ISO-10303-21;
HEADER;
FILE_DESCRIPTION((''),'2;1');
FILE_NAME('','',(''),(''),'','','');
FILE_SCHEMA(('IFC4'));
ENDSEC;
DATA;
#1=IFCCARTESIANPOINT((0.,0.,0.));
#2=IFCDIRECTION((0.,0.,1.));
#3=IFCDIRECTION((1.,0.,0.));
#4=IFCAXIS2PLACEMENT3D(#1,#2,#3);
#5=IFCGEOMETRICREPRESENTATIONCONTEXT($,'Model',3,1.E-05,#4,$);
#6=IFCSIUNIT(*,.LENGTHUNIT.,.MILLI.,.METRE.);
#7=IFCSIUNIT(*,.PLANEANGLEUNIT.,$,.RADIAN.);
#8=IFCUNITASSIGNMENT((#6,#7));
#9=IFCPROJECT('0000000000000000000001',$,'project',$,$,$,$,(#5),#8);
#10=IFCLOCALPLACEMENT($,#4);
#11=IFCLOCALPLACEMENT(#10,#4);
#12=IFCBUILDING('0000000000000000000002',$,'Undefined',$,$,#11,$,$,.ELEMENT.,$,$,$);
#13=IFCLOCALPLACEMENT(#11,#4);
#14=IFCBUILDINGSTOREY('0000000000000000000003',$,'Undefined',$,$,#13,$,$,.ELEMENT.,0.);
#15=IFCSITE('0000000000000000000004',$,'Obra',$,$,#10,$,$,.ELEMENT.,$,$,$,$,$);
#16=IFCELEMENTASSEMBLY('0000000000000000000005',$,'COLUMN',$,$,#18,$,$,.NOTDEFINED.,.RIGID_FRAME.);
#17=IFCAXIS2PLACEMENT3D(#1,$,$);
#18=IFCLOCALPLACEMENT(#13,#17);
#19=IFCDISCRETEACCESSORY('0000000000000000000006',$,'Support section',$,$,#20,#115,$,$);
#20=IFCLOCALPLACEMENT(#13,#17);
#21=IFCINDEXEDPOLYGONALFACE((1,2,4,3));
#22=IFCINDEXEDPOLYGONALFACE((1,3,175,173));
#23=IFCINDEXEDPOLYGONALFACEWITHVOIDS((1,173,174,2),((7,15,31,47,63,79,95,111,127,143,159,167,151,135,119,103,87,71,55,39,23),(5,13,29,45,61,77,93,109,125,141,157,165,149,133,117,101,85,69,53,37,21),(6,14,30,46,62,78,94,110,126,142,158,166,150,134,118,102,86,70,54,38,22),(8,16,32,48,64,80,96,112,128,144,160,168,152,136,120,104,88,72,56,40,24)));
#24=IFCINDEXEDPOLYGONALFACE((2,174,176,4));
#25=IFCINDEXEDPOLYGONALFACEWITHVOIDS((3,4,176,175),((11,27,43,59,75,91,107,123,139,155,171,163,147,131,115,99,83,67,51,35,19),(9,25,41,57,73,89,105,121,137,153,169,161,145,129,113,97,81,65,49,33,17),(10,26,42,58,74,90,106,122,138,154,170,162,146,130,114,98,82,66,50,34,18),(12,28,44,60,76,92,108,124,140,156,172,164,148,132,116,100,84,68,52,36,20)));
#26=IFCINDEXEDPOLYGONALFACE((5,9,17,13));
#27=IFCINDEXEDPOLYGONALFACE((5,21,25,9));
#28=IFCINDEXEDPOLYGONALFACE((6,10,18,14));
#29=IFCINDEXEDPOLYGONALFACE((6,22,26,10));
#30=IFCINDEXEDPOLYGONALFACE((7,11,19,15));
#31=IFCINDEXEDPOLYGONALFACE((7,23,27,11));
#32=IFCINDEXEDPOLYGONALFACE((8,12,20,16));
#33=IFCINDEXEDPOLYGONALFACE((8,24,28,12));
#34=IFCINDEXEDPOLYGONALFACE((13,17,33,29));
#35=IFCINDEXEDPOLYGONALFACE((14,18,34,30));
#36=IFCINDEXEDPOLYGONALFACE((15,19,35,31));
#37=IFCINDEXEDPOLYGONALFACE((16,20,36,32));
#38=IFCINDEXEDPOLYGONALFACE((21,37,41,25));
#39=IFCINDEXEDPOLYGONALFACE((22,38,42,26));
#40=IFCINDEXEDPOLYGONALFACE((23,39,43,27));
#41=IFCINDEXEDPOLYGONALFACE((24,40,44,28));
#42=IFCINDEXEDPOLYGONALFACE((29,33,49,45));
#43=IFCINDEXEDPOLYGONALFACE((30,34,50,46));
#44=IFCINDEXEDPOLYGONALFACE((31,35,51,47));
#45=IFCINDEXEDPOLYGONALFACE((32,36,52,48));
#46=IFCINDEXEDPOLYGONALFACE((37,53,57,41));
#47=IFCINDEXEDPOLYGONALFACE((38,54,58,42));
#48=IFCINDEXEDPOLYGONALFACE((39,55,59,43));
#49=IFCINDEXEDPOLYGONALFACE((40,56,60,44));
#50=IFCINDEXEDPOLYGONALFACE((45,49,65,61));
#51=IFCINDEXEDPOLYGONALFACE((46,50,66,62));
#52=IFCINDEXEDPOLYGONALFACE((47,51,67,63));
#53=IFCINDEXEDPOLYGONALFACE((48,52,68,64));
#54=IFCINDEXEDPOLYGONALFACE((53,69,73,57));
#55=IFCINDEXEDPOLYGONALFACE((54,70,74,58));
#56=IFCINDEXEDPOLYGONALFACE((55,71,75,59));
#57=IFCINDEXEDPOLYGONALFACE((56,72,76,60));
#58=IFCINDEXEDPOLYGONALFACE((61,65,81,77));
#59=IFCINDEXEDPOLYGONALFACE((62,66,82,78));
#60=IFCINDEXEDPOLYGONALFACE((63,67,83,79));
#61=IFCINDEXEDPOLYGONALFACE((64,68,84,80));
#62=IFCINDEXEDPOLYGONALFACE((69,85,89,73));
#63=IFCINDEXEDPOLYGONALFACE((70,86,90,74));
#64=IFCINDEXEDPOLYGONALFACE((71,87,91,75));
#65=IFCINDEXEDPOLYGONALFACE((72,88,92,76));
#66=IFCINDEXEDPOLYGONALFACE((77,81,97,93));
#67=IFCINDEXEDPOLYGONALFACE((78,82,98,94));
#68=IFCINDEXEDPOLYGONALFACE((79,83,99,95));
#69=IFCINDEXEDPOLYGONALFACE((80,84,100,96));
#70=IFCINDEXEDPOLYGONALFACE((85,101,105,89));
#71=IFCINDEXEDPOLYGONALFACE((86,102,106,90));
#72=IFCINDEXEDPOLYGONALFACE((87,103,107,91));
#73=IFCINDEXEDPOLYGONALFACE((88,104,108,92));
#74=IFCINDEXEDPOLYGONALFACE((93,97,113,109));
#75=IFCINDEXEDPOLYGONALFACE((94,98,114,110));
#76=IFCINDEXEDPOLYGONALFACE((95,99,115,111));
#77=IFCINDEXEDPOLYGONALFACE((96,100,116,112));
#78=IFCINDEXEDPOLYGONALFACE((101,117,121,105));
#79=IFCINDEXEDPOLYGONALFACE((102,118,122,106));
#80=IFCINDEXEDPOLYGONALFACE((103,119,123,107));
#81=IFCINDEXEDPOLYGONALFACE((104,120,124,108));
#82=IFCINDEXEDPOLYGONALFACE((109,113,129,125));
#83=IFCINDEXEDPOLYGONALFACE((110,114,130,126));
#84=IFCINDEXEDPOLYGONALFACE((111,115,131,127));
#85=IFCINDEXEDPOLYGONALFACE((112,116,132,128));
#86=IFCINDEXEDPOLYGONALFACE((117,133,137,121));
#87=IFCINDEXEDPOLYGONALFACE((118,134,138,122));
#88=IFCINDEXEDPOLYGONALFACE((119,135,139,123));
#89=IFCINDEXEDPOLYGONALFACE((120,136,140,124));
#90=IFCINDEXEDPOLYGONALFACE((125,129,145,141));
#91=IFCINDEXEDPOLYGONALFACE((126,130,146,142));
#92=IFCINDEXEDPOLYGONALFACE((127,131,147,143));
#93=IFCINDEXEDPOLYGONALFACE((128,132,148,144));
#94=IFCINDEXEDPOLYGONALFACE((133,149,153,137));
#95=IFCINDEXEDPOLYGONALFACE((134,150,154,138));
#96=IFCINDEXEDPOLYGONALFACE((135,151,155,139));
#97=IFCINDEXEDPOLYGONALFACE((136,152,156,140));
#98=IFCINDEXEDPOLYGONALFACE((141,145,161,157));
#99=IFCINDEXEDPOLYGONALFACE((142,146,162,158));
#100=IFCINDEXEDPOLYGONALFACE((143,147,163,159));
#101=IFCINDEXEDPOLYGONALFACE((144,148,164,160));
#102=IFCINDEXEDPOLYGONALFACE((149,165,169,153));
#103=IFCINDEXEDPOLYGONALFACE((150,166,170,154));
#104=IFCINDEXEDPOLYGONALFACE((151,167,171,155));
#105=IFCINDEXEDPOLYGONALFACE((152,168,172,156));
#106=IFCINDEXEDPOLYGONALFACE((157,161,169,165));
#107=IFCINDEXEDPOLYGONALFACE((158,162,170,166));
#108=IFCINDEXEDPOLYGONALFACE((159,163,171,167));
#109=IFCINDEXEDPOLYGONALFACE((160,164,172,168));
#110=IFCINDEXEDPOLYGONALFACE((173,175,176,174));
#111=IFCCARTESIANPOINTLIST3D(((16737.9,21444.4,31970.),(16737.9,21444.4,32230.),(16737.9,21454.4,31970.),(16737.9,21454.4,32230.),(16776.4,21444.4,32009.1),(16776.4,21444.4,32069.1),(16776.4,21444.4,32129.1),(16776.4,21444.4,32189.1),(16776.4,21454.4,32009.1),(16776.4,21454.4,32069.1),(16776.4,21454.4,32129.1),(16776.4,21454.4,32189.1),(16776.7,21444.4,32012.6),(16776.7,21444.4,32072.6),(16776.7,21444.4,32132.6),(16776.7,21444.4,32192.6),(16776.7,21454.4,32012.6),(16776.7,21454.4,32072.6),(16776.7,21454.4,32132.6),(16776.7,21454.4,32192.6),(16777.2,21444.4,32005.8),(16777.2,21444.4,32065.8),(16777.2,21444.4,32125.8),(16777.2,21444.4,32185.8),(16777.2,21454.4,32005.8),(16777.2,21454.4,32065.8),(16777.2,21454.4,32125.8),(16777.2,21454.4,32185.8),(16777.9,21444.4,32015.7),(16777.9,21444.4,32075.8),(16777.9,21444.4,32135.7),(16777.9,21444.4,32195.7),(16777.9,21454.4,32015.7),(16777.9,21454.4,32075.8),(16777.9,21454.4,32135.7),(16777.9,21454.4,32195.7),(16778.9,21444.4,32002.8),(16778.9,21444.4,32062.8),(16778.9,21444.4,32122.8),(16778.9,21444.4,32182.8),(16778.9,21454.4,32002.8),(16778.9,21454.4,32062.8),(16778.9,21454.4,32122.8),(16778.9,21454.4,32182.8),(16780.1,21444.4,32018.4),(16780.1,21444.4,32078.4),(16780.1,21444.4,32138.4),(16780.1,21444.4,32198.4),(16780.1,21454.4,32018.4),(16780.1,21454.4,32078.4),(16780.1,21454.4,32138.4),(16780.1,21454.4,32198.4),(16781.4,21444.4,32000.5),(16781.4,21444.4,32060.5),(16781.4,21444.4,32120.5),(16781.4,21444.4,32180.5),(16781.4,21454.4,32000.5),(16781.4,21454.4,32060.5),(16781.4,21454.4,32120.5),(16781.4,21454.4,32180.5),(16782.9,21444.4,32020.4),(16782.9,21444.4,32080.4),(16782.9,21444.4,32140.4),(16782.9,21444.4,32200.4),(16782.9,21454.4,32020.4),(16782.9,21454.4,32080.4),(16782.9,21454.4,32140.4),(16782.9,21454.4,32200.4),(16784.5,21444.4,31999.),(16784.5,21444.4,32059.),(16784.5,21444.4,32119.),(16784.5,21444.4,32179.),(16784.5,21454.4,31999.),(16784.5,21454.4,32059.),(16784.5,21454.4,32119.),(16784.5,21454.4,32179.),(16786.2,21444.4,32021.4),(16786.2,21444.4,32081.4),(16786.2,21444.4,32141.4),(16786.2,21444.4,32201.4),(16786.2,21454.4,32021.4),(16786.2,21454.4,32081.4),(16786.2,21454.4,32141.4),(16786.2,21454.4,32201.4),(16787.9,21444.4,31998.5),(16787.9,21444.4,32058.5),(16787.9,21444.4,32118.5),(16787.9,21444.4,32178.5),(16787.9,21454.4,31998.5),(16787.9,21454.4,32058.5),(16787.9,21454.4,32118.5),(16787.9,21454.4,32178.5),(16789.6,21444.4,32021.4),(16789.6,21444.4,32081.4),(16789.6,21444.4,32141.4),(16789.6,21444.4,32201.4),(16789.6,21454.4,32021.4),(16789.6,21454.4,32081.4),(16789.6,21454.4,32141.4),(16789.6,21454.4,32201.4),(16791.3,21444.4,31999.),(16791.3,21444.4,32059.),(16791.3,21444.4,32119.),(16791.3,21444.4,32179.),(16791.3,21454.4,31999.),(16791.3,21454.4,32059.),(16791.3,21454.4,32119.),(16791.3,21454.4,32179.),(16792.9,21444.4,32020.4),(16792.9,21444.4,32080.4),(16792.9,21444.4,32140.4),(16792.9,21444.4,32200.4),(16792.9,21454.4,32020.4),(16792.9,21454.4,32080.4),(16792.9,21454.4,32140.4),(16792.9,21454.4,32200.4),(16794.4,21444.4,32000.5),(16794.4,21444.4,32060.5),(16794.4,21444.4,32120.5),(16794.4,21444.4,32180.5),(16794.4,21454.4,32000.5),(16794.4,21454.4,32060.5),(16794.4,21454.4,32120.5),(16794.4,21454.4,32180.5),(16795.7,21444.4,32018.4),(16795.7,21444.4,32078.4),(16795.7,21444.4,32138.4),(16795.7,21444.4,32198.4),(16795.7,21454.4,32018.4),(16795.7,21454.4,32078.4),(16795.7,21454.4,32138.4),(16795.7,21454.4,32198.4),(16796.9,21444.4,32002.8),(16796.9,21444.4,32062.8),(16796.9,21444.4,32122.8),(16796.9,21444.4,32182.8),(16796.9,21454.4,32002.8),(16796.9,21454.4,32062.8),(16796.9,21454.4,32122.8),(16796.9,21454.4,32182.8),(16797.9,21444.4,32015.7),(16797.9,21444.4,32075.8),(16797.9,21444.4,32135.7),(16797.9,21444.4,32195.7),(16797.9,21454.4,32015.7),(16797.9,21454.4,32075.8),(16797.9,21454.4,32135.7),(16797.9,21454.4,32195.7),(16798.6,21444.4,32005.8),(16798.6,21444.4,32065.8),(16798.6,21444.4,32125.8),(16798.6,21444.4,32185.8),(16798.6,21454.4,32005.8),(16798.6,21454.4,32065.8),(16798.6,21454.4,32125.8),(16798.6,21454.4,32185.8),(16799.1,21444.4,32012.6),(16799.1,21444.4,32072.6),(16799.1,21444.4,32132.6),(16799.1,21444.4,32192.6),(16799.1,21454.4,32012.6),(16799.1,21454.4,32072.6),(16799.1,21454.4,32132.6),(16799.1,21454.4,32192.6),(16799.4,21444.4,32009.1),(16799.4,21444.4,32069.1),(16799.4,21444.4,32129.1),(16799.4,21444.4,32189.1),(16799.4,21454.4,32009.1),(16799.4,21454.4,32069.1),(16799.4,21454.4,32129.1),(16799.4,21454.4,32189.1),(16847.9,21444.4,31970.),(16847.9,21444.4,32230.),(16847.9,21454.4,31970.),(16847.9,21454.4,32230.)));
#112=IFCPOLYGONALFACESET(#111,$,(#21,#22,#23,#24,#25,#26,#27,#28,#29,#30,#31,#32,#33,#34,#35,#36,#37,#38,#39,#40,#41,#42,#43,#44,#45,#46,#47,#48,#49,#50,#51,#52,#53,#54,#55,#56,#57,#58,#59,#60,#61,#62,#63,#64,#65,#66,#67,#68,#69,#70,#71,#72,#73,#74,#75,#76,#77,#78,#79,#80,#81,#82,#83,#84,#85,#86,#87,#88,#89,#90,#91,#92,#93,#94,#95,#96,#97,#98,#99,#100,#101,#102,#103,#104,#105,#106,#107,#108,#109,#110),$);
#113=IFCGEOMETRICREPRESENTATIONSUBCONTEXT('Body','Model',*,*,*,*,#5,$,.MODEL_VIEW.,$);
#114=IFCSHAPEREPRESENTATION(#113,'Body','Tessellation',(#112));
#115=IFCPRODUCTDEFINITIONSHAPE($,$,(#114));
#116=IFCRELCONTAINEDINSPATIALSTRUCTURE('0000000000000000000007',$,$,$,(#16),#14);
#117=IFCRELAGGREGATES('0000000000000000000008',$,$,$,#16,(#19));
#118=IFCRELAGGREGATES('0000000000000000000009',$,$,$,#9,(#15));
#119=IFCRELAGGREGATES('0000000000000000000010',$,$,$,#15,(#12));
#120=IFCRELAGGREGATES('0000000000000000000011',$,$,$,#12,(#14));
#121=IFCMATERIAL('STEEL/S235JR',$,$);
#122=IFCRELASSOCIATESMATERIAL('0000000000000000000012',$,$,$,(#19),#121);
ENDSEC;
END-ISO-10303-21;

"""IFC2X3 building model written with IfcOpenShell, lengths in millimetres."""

from ifc_helpers import new_model, si_unit, frame, origin_with_axes, origin_2d_with_axis, place, context, subcontext, project, spatial, rectangle, circle, extrude, source, transform, mapped, material, element, aggregate, save


model = new_model("IFC2X3")

# Units and contexts
model_context = context("Model", 3, precision=1e-05, world=origin_with_axes())
body_context = subcontext(model_context, "Body", "Model", "MODEL_VIEW")
ifc_project = project(units=[si_unit("LENGTHUNIT", "METRE", prefix="MILLI"), si_unit("PLANEANGLEUNIT", "RADIAN")], contexts=[model_context])

# Site, building, storey
site_placement = place(None, origin_with_axes())
site = spatial("IfcSite", under=ifc_project, at=site_placement, Name="Obra", CompositionType="ELEMENT")
building_placement = place(site_placement, origin_with_axes())
building = spatial("IfcBuilding", under=site, at=building_placement, Name="Undefined", CompositionType="ELEMENT")
storey_placement = place(building_placement, origin_with_axes())
storey = spatial("IfcBuildingStorey", under=building, at=storey_placement, Name="Undefined", CompositionType="ELEMENT", Elevation=0.0)

# Shared definitions
ifc_material_1 = material(Name="STEEL/S235JR")

# Shared definitions
shared_shape_1 = source(origin_with_axes(), body_context, "Body", "SweptSolid", [
    extrude(circle(Radius=11.5, at=origin_2d_with_axis()), frame((0.0, -14.4, 0.0), z_axis=(0.0, 1.0, 0.0), x_axis=(1.0, 0.0, 0.0)), (0.0, 0.0, 1.0), 10.2),
])

# Element assembly, discrete accessory, opening
assembly_1_placement = place(storey_placement, origin_with_axes())
assembly_1 = element("IfcElementAssembly", 1, at=assembly_1_placement, inside=storey, Name="COLUMN", AssemblyPlace="NOTDEFINED", PredefinedType="RIGID_FRAME")
discrete_accessory_1_placement = place(assembly_1_placement, frame((16792.9, 21449.4, 31970.0), z_axis=(0.0, 0.0, 1.0), x_axis=(1.0, 0.0, 0.0)))
discrete_accessory_1 = element("IfcDiscreteAccessory", 2, at=discrete_accessory_1_placement, material=ifc_material_1, Name="Support section", context=body_context, shape_type="SweptSolid", body=[
    extrude(rectangle(XDim=10.0, YDim=110.0, at=origin_2d_with_axis()), frame((0.0, 0.0, 260.0), z_axis=(0.0, 0.0, -1.0), x_axis=(0.0, 1.0, 0.0)), (0.0, 0.0, 1.0), 260.0),
])
opening_1_placement = place(assembly_1_placement, frame((16837.9, 21440.1, 32300.0), z_axis=(-1.0, 0.0, 0.0), x_axis=(0.0, 0.0, -1.0)))
element("IfcOpeningElement", 3, at=opening_1_placement, cuts=discrete_accessory_1, ObjectType="Opening", context=body_context, shape_type="MappedRepresentation", body=[
    mapped(shared_shape_1, transform((110.0, 0.0, 50.0))),
    mapped(shared_shape_1, transform((170.0, 0.0, 50.0))),
    mapped(shared_shape_1, transform((230.0, 0.0, 50.0))),
    mapped(shared_shape_1, transform((290.0, 0.0, 50.0))),
])

aggregate(assembly_1, [discrete_accessory_1])

save(model, "model.ifc")
